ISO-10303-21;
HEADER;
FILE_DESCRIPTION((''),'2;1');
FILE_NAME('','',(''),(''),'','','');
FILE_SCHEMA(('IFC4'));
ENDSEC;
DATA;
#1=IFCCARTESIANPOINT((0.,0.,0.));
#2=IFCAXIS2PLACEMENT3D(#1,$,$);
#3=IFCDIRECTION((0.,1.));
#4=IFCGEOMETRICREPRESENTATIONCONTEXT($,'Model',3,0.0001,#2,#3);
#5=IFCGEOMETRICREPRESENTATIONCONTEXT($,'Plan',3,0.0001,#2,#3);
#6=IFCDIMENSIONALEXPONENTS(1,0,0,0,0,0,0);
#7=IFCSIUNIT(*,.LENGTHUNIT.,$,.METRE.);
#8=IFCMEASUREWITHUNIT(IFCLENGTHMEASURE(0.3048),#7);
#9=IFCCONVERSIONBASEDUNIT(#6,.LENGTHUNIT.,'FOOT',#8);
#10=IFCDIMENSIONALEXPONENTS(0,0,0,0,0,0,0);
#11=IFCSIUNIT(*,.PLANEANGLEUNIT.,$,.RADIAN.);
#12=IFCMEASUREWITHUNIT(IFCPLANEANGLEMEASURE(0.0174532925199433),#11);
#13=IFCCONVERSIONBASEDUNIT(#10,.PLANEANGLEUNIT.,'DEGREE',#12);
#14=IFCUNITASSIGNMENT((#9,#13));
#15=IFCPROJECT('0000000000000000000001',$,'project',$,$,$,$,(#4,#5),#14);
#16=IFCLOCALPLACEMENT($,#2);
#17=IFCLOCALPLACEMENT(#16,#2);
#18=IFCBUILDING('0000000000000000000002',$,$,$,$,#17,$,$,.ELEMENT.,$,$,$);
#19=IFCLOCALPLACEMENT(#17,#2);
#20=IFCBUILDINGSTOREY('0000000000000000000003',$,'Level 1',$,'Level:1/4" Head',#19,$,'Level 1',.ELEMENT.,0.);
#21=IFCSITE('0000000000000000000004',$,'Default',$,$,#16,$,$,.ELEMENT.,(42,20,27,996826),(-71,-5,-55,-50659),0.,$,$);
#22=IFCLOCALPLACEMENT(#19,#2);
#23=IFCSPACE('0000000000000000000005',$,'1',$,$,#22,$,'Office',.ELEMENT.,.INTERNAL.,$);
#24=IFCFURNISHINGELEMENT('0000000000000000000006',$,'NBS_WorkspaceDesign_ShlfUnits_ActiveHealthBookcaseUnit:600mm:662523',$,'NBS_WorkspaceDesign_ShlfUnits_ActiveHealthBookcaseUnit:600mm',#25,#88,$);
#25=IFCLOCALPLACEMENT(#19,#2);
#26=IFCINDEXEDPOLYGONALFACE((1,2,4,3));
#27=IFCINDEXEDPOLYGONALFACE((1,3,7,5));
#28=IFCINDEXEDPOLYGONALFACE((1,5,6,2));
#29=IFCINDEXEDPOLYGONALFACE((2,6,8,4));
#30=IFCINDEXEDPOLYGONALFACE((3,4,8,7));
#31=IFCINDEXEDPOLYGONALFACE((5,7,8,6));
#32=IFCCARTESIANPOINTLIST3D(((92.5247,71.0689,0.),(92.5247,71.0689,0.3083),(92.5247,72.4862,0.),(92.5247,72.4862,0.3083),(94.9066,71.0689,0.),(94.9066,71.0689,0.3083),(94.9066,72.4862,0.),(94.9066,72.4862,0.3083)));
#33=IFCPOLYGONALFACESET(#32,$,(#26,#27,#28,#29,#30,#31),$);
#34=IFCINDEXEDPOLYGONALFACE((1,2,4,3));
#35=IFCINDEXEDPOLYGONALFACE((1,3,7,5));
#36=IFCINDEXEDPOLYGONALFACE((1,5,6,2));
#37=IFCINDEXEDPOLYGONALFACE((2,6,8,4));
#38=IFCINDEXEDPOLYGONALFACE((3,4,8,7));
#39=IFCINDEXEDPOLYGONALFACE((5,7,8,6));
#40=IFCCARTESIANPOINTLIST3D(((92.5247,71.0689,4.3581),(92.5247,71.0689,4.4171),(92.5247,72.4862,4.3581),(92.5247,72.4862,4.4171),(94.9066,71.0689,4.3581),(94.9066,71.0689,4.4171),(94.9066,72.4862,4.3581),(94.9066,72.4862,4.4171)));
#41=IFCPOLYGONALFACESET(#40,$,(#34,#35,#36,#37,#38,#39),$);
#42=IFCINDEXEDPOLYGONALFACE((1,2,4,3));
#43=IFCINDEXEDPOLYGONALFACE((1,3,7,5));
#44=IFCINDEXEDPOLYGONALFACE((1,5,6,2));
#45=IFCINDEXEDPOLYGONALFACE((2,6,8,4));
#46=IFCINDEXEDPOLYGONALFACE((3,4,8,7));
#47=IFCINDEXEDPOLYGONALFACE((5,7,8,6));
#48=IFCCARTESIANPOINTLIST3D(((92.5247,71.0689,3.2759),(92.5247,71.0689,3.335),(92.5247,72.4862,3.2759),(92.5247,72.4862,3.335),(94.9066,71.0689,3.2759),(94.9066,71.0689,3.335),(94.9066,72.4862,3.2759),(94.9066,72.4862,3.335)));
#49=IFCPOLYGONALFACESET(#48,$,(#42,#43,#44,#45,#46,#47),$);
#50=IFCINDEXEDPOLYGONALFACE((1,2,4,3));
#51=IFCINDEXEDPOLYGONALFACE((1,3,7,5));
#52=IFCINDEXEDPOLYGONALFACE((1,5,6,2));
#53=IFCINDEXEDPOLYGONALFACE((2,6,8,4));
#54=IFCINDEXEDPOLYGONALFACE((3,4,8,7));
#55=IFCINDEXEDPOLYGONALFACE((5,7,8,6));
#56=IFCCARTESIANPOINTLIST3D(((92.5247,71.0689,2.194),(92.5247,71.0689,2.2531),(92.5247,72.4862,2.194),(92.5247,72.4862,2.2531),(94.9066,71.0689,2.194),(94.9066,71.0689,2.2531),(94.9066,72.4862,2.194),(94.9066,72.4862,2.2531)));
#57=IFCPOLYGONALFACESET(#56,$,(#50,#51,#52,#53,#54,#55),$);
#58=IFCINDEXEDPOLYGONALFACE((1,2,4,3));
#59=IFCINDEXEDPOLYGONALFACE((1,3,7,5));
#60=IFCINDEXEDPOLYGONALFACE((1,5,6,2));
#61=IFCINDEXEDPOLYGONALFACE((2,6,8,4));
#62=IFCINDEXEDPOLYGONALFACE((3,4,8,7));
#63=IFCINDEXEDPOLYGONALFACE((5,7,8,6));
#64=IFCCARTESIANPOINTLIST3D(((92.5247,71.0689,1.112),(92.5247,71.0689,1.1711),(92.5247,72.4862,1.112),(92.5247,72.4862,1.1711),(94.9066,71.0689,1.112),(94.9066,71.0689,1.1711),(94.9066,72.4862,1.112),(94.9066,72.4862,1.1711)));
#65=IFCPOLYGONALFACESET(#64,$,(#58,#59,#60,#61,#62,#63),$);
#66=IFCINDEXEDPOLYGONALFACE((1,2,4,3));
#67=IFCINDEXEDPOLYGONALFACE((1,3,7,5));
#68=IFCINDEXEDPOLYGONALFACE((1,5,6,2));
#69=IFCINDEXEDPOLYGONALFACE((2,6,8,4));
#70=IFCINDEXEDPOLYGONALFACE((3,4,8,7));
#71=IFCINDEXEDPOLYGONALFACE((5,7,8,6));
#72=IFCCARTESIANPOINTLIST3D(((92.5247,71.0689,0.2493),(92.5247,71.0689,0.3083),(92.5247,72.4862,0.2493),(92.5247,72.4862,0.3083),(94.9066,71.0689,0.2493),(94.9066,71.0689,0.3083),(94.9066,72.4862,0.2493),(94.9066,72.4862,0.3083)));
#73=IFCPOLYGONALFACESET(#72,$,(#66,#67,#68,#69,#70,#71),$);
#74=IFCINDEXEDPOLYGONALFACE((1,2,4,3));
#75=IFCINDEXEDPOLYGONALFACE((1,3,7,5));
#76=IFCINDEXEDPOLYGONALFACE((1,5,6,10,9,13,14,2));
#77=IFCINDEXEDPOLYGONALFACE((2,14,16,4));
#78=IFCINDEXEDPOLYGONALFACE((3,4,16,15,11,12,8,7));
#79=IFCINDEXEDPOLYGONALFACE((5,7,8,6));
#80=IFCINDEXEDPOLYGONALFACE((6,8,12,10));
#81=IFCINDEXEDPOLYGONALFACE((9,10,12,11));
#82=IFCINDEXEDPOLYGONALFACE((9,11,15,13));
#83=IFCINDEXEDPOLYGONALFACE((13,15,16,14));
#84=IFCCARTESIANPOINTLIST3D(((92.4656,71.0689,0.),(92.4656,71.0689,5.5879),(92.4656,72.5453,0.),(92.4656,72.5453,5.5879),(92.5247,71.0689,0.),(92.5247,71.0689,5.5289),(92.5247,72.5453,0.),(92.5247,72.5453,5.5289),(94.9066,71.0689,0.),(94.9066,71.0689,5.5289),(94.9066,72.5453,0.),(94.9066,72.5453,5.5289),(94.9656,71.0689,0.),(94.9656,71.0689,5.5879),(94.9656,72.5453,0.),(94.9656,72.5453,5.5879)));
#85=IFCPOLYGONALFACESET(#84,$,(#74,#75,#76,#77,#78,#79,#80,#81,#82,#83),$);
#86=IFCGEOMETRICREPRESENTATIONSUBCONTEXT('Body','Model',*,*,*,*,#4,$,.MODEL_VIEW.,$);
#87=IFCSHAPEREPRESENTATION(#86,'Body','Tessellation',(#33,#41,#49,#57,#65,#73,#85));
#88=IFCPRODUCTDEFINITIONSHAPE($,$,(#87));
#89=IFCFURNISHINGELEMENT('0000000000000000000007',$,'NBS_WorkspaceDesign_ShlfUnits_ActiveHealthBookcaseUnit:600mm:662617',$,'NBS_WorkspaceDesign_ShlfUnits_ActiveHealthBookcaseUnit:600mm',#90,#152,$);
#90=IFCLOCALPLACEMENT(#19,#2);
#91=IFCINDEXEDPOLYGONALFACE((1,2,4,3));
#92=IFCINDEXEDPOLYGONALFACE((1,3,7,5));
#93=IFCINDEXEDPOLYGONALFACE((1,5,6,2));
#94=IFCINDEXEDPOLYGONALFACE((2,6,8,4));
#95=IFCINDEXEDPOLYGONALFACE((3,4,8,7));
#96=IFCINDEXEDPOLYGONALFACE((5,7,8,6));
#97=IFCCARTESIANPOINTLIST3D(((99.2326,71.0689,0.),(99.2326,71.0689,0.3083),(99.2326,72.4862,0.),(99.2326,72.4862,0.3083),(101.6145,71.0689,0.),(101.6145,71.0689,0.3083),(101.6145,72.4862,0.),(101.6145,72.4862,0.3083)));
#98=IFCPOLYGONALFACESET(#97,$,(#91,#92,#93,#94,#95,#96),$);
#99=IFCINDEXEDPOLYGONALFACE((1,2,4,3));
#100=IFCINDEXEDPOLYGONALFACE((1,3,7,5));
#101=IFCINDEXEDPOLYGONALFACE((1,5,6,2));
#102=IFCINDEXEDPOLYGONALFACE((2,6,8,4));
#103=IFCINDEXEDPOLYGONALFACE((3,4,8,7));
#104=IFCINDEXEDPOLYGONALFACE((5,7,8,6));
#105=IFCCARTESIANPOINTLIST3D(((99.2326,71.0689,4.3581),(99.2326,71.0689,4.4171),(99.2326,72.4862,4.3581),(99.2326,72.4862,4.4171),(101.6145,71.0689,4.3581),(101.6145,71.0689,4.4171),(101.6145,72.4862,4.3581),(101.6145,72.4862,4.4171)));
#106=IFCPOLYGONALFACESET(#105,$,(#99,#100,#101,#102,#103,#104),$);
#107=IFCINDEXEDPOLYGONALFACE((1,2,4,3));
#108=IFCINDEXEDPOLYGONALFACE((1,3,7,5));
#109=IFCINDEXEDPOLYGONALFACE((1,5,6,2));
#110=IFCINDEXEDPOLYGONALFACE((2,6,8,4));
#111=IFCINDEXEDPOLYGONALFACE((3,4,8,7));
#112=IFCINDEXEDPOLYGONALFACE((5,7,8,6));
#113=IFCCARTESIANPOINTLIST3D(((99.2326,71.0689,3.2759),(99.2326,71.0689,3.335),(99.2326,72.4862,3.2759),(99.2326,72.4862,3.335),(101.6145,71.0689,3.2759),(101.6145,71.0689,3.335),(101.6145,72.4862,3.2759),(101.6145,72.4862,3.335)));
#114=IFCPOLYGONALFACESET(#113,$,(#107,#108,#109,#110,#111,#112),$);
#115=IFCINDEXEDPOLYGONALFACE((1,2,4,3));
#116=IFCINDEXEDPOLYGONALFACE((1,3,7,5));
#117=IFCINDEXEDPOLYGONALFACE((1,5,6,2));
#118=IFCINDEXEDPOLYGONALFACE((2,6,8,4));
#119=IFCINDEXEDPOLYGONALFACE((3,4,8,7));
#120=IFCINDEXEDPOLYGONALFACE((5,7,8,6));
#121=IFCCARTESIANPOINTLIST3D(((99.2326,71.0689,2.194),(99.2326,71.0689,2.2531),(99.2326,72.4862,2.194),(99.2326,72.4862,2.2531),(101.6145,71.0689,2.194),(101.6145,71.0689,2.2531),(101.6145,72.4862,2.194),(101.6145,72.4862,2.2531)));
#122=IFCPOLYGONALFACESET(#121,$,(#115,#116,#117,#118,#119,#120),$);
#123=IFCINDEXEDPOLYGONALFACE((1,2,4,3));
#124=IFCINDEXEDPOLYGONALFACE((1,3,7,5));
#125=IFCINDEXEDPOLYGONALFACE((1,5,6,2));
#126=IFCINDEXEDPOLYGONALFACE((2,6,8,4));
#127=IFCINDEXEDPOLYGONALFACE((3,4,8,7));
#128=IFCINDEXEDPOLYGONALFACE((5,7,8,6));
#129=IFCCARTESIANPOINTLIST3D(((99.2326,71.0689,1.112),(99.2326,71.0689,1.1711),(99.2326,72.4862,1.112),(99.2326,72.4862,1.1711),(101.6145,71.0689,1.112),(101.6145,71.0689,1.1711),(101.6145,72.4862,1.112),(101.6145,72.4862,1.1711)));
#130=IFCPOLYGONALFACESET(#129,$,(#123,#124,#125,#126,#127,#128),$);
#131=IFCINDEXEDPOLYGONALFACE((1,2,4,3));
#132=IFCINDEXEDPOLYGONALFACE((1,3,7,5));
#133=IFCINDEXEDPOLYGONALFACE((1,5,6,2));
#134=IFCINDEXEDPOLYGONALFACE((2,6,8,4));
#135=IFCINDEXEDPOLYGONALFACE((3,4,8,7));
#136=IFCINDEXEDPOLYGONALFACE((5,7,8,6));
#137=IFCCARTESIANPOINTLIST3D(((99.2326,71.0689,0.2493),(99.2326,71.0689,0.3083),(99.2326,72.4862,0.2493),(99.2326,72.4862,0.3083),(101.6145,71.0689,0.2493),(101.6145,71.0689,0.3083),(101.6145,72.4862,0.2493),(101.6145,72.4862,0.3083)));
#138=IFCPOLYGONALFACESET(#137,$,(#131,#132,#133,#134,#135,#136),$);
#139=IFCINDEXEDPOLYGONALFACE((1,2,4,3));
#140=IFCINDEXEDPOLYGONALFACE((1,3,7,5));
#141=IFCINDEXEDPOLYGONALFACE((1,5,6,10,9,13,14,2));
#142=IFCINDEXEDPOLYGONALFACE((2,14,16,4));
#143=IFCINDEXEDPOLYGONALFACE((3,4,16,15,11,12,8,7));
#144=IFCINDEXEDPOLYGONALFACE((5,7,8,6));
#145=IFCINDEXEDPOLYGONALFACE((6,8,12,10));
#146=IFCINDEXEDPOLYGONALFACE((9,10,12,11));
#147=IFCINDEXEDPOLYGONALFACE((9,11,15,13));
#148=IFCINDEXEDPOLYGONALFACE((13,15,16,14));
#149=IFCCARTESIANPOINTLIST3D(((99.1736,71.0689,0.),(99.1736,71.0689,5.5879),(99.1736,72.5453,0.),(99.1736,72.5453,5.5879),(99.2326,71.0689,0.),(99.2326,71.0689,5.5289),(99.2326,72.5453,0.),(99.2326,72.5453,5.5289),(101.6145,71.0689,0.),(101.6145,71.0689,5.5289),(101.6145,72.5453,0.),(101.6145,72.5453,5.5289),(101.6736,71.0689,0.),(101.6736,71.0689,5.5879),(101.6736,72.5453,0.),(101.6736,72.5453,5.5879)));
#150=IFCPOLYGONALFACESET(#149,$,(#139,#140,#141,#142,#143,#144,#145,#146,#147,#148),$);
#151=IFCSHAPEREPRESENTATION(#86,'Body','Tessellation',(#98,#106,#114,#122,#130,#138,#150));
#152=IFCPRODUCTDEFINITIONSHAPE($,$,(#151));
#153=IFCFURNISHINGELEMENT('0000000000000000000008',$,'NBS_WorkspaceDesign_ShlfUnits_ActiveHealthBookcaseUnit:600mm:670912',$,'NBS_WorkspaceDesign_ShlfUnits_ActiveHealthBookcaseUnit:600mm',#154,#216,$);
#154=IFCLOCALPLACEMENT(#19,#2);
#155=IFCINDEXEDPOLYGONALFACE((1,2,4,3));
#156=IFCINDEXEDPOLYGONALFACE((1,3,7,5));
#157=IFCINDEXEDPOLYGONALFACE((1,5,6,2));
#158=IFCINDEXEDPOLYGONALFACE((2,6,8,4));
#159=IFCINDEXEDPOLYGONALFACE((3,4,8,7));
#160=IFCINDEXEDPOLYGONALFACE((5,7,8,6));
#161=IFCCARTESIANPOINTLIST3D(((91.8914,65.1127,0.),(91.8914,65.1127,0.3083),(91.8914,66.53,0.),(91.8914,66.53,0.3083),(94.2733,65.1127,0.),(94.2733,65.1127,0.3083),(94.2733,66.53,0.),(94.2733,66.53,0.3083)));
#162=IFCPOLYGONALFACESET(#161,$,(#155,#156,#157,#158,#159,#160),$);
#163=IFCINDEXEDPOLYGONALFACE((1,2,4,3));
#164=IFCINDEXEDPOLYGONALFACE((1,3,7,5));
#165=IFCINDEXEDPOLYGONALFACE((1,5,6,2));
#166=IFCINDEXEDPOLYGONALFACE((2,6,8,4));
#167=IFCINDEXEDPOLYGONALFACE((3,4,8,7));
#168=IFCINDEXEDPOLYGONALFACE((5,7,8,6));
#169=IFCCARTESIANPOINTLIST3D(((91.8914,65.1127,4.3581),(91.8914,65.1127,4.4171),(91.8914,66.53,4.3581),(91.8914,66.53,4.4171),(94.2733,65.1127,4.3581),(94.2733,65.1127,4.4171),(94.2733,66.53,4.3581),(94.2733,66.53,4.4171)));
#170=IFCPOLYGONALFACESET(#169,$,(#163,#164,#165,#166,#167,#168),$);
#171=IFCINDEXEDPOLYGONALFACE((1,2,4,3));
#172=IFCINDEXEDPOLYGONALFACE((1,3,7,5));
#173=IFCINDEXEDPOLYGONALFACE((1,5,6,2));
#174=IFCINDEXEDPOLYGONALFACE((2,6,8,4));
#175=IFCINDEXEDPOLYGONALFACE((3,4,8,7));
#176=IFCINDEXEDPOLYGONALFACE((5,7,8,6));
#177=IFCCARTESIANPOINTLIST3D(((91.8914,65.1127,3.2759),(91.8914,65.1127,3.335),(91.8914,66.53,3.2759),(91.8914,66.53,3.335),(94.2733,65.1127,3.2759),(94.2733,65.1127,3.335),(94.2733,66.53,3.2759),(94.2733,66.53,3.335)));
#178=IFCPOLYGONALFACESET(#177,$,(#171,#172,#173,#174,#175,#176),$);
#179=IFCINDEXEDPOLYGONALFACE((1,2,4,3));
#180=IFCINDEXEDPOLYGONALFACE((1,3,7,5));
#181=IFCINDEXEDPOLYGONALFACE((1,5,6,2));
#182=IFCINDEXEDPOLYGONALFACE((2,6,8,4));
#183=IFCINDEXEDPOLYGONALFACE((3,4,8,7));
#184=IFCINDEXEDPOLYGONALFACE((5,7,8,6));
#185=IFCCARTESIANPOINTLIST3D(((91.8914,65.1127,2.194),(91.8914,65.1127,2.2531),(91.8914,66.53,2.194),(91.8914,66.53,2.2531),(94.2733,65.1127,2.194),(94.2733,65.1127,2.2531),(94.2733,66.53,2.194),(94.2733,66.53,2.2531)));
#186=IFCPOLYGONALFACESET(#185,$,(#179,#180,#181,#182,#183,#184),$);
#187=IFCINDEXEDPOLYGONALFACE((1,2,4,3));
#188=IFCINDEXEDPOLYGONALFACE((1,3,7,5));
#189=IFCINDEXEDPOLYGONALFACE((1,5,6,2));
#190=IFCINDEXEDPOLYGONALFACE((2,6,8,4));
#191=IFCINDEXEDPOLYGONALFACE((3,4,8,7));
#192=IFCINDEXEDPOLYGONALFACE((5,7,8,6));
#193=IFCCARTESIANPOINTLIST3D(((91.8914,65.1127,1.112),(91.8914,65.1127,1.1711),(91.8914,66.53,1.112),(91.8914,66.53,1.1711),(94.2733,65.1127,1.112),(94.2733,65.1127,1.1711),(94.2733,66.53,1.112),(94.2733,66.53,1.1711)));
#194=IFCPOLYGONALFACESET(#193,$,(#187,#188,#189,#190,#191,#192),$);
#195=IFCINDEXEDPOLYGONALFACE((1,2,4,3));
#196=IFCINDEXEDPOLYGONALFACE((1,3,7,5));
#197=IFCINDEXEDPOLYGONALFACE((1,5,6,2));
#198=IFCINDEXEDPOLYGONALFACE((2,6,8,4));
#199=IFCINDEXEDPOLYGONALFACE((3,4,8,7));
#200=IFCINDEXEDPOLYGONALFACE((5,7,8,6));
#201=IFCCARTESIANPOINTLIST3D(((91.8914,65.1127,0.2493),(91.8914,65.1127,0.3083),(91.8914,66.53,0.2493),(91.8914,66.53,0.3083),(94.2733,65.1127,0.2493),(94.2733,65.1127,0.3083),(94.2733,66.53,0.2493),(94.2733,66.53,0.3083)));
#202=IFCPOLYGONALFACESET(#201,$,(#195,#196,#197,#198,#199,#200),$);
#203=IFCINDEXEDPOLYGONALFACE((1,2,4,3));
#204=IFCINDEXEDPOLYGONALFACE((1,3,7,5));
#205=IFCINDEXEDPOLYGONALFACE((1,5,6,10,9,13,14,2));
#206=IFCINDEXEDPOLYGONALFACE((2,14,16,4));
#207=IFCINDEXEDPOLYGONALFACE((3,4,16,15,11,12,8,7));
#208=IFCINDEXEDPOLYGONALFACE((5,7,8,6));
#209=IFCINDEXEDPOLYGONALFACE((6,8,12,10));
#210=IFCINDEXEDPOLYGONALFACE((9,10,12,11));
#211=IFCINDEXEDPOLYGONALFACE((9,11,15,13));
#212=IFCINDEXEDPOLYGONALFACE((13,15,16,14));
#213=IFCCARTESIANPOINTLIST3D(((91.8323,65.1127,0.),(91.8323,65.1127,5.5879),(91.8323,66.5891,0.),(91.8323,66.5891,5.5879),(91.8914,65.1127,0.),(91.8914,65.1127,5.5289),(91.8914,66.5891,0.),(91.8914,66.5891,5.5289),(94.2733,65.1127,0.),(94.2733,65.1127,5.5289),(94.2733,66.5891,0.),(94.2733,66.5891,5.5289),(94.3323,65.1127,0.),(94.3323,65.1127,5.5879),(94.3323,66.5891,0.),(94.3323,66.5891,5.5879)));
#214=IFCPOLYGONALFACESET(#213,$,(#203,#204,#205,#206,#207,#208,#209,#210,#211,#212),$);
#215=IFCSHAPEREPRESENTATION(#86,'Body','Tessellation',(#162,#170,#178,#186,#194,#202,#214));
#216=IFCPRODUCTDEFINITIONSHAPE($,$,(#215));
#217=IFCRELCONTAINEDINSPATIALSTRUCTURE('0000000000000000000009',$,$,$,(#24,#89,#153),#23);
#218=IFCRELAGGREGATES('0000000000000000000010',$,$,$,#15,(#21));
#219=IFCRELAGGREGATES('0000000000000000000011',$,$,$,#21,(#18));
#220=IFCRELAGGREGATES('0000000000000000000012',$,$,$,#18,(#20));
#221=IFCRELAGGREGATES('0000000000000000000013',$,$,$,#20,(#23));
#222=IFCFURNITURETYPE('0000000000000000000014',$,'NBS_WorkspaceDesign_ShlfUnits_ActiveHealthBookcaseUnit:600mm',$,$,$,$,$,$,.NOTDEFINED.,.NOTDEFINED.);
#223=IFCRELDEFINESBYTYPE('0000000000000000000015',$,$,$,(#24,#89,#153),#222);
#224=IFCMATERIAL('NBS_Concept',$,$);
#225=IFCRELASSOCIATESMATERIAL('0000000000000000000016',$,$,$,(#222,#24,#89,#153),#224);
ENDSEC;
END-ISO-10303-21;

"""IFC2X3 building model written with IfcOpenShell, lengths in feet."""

from ifc_helpers import new_model, entity, si_unit, converted_unit, direction, frame, frame_2d, origin, place, context, subcontext, project, spatial, polyline, rectangle, outline, extrude, source, transform, mapped, material, type_object, type_shapes, element, save


model = new_model("IFC2X3")

# Units and contexts
model_context = context("Model", 3, precision=0.0001, world=origin(), true_north=direction((0.0, 1.0)))
plan_context = context("Plan", 3, precision=0.0001, world=origin(), true_north=direction((0.0, 1.0)))
body_context = subcontext(model_context, "Body", "Model", "MODEL_VIEW")
ifc_project = project(units=[converted_unit("LENGTHUNIT", "FOOT", entity("IfcLengthMeasure", 0.3048), si_unit("LENGTHUNIT", "METRE"), dimensions=[1, 0, 0, 0, 0, 0, 0]), converted_unit("PLANEANGLEUNIT", "DEGREE", entity("IfcPlaneAngleMeasure", 0.0174532925199433), si_unit("PLANEANGLEUNIT", "RADIAN"), dimensions=[0, 0, 0, 0, 0, 0, 0])], contexts=[model_context, plan_context])

# Site, building, storey
site_placement = place(None, origin())
site = spatial("IfcSite", under=ifc_project, at=site_placement, Name="Default", CompositionType="ELEMENT", RefLatitude=(42, 20, 27, 996826), RefLongitude=(-71, -5, -55, -50659), RefElevation=0.0)
building_placement = place(site_placement, origin())
building = spatial("IfcBuilding", under=site, at=building_placement, CompositionType="ELEMENT")
storey_placement = place(building_placement, origin())
storey = spatial("IfcBuildingStorey", under=building, at=storey_placement, Name="Level 1", ObjectType="Level:1/4\" Head", LongName="Level 1", CompositionType="ELEMENT", Elevation=0.0)

# Shared definitions
space_placement = place(storey_placement, origin())
space = spatial("IfcSpace", under=storey, at=space_placement, Name="1", LongName="Office", CompositionType="ELEMENT", InteriorOrExteriorSpace="INTERNAL")

# Furnishing elements
ifc_material_1 = material(Name="NBS_Concept")
furniture_type_1 = type_object("IfcFurnitureType", Name="NBS_WorkspaceDesign_ShlfUnits_ActiveHealthBookcaseUnit:600mm", AssemblyPlace="NOTDEFINED", material=ifc_material_1)
shared_shape_1 = source(origin(), body_context, "Body", "SweptSolid", [
    extrude(rectangle(XDim=1.4173, YDim=2.3819, at=frame_2d((0.0, 0.0), x_axis=(1.0, 0.0))), frame((0.0, -0.7677, 0.0), z_axis=(0.0, 0.0, 1.0), x_axis=(0.0, 1.0, 0.0)), (0.0, 0.0, 1.0), 0.3083),
    extrude(rectangle(XDim=1.4173, YDim=2.3819, at=frame_2d((0.0, 0.0), x_axis=(1.0, 0.0))), frame((0.0, -0.7677, 4.3581), z_axis=(0.0, 0.0, 1.0), x_axis=(0.0, 1.0, 0.0)), (0.0, 0.0, 1.0), 0.0591),
    extrude(rectangle(XDim=1.4173, YDim=2.3819, at=frame_2d((0.0, 0.0), x_axis=(1.0, 0.0))), frame((0.0, -0.7677, 3.2759), z_axis=(0.0, 0.0, 1.0), x_axis=(0.0, 1.0, 0.0)), (0.0, 0.0, 1.0), 0.0591),
    extrude(rectangle(XDim=1.4173, YDim=2.3819, at=frame_2d((0.0, 0.0), x_axis=(1.0, 0.0))), frame((0.0, -0.7677, 2.194), z_axis=(0.0, 0.0, 1.0), x_axis=(0.0, 1.0, 0.0)), (0.0, 0.0, 1.0), 0.0591),
    extrude(rectangle(XDim=1.4173, YDim=2.3819, at=frame_2d((0.0, 0.0), x_axis=(1.0, 0.0))), frame((0.0, -0.7677, 1.112), z_axis=(0.0, 0.0, 1.0), x_axis=(0.0, 1.0, 0.0)), (0.0, 0.0, 1.0), 0.0591),
    extrude(rectangle(XDim=1.4173, YDim=2.3819, at=frame_2d((0.0, 0.0), x_axis=(1.0, 0.0))), frame((0.0, -0.7677, 0.2493), z_axis=(0.0, 0.0, 1.0), x_axis=(0.0, 1.0, 0.0)), (0.0, 0.0, 1.0), 0.0591),
    extrude(outline(polyline([(-2.8087, -1.25), (2.7792, -1.25), (2.7792, -1.1909), (-2.7497, -1.1909), (-2.7497, 1.1909), (2.7792, 1.1909), (2.7792, 1.25), (-2.8087, 1.25), (-2.8087, -1.25)])), frame((0.0, -1.4764, 2.7792), z_axis=(0.0, 1.0, 0.0), x_axis=(0.0, 0.0, -1.0)), (0.0, 0.0, 1.0), 1.4764),
])
type_shapes(furniture_type_1, [shared_shape_1])
for number, where, name in (
    (1, (93.7156, 72.5453, 0.0), "NBS_WorkspaceDesign_ShlfUnits_ActiveHealthBookcaseUnit:600mm:662523"),
    (2, (100.4236, 72.5453, 0.0), "NBS_WorkspaceDesign_ShlfUnits_ActiveHealthBookcaseUnit:600mm:662617"),
    (3, (93.0823, 66.5891, 0.0), "NBS_WorkspaceDesign_ShlfUnits_ActiveHealthBookcaseUnit:600mm:670912"),
):
    element("IfcFurnishingElement", number, at=place(space_placement, frame(where)), inside=space, type_object=furniture_type_1, material=ifc_material_1, Name=name, ObjectType="NBS_WorkspaceDesign_ShlfUnits_ActiveHealthBookcaseUnit:600mm", context=body_context, shape_type="MappedRepresentation", body=[
        mapped(shared_shape_1, transform((0.0, 0.0, 0.0), scale=1.0)),
    ])

save(model, "model.ifc")
